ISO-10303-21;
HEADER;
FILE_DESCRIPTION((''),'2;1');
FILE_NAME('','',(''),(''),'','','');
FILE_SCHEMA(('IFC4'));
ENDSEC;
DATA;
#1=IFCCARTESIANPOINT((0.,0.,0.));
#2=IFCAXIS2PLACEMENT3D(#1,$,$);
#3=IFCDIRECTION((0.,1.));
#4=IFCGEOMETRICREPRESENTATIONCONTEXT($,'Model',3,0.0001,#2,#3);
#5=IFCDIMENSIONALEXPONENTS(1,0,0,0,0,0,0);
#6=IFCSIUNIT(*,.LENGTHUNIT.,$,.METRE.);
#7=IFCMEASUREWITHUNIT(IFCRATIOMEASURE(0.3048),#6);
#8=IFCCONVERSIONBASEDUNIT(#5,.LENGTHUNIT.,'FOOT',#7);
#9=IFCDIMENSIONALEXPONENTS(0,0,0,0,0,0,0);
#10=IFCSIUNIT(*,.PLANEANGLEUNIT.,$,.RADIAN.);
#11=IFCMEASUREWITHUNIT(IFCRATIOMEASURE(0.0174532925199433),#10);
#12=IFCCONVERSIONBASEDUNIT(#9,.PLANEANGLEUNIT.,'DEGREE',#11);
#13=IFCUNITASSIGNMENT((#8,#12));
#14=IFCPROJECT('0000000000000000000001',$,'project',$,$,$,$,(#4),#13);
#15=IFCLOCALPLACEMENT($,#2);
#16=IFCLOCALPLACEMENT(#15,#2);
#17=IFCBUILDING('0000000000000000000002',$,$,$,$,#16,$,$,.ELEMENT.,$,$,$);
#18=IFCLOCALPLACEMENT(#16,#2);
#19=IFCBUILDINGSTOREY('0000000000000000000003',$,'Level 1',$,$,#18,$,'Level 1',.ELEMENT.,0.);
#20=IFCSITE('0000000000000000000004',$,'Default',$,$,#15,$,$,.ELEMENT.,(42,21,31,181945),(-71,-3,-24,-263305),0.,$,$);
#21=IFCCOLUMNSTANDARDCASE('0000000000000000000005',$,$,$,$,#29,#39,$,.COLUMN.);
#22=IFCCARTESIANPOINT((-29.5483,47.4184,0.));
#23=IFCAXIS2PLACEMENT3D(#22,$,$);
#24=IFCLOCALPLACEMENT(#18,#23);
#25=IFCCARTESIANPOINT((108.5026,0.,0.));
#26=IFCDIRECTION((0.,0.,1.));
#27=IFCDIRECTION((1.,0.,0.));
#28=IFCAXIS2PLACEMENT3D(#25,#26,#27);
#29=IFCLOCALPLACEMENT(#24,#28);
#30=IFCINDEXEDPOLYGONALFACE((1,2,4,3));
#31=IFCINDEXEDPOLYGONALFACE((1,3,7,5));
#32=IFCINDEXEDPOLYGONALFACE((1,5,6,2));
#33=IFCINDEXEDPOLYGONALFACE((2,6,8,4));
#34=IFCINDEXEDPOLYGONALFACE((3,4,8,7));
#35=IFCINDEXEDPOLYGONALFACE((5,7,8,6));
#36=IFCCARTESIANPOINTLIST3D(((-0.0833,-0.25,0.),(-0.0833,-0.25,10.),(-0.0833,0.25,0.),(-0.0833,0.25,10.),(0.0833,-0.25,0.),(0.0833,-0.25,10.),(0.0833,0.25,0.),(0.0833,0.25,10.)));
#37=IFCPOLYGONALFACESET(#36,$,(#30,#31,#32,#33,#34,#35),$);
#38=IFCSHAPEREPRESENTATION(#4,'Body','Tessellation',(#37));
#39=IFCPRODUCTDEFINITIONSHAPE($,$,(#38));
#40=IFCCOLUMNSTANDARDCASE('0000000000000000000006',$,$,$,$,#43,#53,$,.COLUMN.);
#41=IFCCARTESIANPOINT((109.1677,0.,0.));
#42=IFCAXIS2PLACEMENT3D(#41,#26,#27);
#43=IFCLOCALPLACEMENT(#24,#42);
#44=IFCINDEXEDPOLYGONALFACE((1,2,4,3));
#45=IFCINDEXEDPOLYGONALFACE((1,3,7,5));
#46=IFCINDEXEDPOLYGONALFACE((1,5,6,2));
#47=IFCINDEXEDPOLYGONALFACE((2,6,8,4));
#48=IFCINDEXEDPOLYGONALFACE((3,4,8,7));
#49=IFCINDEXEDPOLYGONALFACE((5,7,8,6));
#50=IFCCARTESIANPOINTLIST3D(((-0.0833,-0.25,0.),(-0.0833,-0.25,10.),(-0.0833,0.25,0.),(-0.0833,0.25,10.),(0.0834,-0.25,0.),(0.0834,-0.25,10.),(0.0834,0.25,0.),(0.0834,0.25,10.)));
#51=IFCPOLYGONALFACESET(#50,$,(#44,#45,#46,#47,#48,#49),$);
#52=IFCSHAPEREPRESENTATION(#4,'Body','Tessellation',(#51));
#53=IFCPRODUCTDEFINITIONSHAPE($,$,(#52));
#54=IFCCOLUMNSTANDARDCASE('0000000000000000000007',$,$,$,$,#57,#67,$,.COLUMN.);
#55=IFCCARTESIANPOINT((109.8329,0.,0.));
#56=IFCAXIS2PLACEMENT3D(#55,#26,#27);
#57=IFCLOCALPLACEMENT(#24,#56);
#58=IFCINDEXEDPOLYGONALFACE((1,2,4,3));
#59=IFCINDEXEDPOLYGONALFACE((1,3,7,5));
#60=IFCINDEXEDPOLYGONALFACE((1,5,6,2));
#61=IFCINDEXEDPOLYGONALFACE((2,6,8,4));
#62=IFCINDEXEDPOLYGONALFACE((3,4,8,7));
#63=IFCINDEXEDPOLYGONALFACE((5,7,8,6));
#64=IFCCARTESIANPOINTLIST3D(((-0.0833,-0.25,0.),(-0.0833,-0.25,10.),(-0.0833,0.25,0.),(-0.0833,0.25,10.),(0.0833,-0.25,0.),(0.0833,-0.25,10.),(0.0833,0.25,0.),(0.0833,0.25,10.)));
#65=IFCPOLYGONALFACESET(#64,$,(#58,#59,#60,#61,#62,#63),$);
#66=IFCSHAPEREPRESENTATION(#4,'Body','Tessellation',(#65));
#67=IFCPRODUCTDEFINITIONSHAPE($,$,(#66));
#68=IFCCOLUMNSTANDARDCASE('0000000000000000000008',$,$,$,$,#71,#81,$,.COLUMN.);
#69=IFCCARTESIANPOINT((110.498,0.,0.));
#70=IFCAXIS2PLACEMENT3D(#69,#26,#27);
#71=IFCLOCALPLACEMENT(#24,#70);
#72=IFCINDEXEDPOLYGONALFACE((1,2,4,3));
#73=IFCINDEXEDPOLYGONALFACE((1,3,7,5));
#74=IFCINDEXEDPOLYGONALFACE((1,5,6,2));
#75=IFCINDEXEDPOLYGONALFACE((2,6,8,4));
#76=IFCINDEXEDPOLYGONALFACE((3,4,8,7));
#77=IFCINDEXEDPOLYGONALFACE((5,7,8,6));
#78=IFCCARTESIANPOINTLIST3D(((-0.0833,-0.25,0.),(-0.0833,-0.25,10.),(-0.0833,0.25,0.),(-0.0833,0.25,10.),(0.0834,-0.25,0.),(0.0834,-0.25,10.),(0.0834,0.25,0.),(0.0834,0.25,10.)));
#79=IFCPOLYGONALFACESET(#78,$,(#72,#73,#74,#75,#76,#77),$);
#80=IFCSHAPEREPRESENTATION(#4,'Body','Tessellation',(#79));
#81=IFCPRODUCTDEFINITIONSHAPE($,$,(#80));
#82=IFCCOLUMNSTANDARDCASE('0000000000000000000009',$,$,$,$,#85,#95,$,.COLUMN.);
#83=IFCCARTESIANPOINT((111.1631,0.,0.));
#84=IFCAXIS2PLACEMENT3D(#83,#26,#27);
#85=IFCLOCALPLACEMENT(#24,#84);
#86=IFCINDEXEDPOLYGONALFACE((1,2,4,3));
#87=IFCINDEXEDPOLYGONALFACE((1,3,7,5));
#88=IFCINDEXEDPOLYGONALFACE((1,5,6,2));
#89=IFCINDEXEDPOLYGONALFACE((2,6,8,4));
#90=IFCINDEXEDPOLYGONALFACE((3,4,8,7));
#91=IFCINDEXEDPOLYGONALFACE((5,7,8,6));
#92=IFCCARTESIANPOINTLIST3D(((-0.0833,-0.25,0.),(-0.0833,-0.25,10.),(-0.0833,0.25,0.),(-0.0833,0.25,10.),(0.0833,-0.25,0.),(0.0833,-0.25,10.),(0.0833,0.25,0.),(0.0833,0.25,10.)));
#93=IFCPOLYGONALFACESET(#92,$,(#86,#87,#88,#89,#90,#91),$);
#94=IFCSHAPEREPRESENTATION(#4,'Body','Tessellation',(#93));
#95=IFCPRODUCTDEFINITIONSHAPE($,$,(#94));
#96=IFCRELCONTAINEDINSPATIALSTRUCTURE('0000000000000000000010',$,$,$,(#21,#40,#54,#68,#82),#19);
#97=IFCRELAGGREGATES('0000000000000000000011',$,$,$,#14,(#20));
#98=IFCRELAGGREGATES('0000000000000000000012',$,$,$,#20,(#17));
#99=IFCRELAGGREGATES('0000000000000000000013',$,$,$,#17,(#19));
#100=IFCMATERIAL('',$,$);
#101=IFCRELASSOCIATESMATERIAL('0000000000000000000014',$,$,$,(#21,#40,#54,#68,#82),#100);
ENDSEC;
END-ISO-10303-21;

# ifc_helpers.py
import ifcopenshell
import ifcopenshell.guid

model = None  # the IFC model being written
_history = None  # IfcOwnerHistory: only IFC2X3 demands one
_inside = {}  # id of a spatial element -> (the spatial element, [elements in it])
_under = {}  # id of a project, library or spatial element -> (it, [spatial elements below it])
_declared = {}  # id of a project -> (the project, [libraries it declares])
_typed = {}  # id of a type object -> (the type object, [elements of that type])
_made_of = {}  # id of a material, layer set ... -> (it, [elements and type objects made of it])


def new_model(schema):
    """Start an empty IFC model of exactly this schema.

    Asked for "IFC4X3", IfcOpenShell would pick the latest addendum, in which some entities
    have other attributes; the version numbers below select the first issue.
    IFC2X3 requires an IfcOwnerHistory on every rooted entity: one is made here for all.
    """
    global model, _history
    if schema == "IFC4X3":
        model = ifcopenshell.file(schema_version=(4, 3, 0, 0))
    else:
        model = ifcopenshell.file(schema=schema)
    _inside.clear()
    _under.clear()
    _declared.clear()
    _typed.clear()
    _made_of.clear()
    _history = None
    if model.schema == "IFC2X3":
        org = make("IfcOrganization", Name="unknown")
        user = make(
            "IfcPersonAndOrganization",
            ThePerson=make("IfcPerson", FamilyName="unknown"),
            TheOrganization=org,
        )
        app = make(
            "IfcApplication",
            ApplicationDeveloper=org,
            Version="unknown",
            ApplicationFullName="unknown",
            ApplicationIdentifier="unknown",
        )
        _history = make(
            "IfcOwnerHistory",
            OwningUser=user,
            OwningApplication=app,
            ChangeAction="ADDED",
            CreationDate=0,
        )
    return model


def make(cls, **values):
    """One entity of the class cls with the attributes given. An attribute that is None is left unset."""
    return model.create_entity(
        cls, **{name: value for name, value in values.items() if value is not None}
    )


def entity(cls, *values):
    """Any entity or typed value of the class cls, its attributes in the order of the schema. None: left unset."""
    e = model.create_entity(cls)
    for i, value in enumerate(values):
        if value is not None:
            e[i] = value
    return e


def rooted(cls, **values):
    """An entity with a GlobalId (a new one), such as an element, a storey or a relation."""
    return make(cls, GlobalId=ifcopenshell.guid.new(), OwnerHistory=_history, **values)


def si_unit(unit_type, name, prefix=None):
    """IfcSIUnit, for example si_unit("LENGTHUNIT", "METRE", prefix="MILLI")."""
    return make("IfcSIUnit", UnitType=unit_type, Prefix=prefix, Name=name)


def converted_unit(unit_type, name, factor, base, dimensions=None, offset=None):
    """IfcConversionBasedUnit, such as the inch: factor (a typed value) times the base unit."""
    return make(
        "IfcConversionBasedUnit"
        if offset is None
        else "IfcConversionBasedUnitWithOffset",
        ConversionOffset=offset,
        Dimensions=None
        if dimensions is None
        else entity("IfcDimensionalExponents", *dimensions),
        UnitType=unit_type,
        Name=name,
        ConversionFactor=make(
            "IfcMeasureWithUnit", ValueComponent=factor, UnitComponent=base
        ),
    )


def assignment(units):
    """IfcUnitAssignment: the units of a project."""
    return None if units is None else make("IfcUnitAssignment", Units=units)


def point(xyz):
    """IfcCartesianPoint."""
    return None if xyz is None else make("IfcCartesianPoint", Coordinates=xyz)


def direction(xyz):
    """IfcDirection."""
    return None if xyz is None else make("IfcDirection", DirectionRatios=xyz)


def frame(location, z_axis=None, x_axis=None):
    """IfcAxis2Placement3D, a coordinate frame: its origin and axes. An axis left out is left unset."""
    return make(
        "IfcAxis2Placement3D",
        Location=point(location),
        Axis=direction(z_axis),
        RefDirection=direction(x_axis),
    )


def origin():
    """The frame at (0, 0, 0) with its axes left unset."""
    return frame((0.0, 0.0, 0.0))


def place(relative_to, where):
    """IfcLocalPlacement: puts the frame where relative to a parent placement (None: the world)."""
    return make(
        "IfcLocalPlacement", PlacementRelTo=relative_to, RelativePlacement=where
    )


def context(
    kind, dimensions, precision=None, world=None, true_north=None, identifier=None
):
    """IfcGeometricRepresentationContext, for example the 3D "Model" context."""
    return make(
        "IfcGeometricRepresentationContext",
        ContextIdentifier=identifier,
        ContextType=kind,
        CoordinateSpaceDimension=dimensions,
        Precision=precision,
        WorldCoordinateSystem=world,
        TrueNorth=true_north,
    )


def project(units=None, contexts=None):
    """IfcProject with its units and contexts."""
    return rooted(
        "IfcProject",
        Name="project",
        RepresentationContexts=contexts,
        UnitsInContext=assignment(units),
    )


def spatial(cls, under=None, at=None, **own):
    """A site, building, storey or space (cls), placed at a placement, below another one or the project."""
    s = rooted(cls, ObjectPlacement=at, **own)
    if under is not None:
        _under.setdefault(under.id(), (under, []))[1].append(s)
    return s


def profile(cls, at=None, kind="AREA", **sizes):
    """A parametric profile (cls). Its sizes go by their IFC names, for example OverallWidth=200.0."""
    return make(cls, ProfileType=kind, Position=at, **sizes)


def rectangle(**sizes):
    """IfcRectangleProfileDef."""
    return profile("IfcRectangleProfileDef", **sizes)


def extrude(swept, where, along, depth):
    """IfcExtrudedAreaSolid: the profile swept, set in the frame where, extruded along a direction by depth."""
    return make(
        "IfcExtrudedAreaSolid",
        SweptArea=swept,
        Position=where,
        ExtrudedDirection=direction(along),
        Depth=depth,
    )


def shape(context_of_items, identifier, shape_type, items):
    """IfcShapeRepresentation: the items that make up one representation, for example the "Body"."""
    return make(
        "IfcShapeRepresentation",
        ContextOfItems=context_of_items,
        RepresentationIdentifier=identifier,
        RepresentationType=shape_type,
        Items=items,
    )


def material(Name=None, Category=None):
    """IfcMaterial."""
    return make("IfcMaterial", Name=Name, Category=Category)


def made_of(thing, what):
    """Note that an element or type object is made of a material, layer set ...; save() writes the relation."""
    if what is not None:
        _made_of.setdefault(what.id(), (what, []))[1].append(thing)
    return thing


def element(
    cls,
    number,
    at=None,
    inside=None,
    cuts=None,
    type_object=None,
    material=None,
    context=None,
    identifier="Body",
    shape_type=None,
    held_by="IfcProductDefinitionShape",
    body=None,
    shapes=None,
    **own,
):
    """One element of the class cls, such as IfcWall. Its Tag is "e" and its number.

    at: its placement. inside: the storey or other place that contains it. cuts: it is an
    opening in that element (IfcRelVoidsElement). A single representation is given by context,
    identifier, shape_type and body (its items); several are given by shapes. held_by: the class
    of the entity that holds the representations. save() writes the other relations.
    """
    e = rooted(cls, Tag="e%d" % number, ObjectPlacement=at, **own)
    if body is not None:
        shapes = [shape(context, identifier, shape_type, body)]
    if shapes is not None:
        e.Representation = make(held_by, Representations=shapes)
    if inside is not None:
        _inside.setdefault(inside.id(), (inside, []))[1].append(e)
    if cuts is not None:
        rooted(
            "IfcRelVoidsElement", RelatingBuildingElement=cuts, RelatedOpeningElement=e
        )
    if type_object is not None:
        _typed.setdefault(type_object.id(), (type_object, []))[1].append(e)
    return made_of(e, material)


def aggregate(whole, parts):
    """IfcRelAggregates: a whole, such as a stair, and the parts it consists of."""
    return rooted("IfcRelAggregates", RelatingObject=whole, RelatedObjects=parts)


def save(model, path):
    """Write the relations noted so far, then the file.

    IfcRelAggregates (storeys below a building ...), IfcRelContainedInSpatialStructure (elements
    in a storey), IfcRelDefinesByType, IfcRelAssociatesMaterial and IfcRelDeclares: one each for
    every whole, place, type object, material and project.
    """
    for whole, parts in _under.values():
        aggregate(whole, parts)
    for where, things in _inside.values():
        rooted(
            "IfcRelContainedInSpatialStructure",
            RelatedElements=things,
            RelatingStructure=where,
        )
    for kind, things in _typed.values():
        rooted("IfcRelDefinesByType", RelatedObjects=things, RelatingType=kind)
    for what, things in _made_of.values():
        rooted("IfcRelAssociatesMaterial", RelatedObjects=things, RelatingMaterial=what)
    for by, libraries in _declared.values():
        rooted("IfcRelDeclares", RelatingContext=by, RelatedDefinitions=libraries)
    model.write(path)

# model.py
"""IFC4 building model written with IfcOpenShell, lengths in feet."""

from ifc_helpers import new_model, entity, si_unit, converted_unit, direction, frame, origin, place, context, project, spatial, rectangle, extrude, material, element, save


model = new_model("IFC4")

# Units and contexts
model_context = context("Model", 3, precision=0.0001, world=origin(), true_north=direction((0.0, 1.0)))
ifc_project = project(units=[converted_unit("LENGTHUNIT", "FOOT", entity("IfcRatioMeasure", 0.3048), si_unit("LENGTHUNIT", "METRE"), dimensions=[1, 0, 0, 0, 0, 0, 0]), converted_unit("PLANEANGLEUNIT", "DEGREE", entity("IfcRatioMeasure", 0.0174532925199433), si_unit("PLANEANGLEUNIT", "RADIAN"), dimensions=[0, 0, 0, 0, 0, 0, 0])], contexts=[model_context])

# Site, building, storey
site_placement = place(None, origin())
site = spatial("IfcSite", under=ifc_project, at=site_placement, Name="Default", CompositionType="ELEMENT", RefLatitude=(42, 21, 31, 181945), RefLongitude=(-71, -3, -24, -263305), RefElevation=0.0)
building_placement = place(site_placement, origin())
building = spatial("IfcBuilding", under=site, at=building_placement, CompositionType="ELEMENT")
storey_placement = place(building_placement, origin())
storey = spatial("IfcBuildingStorey", under=building, at=storey_placement, Name="Level 1", LongName="Level 1", CompositionType="ELEMENT", Elevation=0.0)

# Columns
ifc_material = material(Name="")
placement = place(storey_placement, frame((-29.5483, 47.4184, 0.0)))
for number, where, z_axis, x_axis in (
    (1, (108.5026, 0.0, 0.0), (0.0, 0.0, 1.0), (1.0, 0.0, 0.0)),
    (2, (109.1677, 0.0, 0.0), (0.0, 0.0, 1.0), (1.0, 0.0, 0.0)),
    (3, (109.8329, 0.0, 0.0), (0.0, 0.0, 1.0), (1.0, 0.0, 0.0)),
    (4, (110.498, 0.0, 0.0), (0.0, 0.0, 1.0), (1.0, 0.0, 0.0)),
    (5, (111.1631, 0.0, 0.0), (0.0, 0.0, 1.0), (1.0, 0.0, 0.0)),
):
    element("IfcColumnStandardCase", number, at=place(placement, frame(where, z_axis=z_axis, x_axis=x_axis)), inside=storey, material=ifc_material, PredefinedType="COLUMN", context=model_context, shape_type="SweptSolid", body=[
        extrude(rectangle(XDim=0.1667, YDim=0.5), origin(), (0.0, 0.0, 1.0), 10.0),
    ])

save(model, "model.ifc")
